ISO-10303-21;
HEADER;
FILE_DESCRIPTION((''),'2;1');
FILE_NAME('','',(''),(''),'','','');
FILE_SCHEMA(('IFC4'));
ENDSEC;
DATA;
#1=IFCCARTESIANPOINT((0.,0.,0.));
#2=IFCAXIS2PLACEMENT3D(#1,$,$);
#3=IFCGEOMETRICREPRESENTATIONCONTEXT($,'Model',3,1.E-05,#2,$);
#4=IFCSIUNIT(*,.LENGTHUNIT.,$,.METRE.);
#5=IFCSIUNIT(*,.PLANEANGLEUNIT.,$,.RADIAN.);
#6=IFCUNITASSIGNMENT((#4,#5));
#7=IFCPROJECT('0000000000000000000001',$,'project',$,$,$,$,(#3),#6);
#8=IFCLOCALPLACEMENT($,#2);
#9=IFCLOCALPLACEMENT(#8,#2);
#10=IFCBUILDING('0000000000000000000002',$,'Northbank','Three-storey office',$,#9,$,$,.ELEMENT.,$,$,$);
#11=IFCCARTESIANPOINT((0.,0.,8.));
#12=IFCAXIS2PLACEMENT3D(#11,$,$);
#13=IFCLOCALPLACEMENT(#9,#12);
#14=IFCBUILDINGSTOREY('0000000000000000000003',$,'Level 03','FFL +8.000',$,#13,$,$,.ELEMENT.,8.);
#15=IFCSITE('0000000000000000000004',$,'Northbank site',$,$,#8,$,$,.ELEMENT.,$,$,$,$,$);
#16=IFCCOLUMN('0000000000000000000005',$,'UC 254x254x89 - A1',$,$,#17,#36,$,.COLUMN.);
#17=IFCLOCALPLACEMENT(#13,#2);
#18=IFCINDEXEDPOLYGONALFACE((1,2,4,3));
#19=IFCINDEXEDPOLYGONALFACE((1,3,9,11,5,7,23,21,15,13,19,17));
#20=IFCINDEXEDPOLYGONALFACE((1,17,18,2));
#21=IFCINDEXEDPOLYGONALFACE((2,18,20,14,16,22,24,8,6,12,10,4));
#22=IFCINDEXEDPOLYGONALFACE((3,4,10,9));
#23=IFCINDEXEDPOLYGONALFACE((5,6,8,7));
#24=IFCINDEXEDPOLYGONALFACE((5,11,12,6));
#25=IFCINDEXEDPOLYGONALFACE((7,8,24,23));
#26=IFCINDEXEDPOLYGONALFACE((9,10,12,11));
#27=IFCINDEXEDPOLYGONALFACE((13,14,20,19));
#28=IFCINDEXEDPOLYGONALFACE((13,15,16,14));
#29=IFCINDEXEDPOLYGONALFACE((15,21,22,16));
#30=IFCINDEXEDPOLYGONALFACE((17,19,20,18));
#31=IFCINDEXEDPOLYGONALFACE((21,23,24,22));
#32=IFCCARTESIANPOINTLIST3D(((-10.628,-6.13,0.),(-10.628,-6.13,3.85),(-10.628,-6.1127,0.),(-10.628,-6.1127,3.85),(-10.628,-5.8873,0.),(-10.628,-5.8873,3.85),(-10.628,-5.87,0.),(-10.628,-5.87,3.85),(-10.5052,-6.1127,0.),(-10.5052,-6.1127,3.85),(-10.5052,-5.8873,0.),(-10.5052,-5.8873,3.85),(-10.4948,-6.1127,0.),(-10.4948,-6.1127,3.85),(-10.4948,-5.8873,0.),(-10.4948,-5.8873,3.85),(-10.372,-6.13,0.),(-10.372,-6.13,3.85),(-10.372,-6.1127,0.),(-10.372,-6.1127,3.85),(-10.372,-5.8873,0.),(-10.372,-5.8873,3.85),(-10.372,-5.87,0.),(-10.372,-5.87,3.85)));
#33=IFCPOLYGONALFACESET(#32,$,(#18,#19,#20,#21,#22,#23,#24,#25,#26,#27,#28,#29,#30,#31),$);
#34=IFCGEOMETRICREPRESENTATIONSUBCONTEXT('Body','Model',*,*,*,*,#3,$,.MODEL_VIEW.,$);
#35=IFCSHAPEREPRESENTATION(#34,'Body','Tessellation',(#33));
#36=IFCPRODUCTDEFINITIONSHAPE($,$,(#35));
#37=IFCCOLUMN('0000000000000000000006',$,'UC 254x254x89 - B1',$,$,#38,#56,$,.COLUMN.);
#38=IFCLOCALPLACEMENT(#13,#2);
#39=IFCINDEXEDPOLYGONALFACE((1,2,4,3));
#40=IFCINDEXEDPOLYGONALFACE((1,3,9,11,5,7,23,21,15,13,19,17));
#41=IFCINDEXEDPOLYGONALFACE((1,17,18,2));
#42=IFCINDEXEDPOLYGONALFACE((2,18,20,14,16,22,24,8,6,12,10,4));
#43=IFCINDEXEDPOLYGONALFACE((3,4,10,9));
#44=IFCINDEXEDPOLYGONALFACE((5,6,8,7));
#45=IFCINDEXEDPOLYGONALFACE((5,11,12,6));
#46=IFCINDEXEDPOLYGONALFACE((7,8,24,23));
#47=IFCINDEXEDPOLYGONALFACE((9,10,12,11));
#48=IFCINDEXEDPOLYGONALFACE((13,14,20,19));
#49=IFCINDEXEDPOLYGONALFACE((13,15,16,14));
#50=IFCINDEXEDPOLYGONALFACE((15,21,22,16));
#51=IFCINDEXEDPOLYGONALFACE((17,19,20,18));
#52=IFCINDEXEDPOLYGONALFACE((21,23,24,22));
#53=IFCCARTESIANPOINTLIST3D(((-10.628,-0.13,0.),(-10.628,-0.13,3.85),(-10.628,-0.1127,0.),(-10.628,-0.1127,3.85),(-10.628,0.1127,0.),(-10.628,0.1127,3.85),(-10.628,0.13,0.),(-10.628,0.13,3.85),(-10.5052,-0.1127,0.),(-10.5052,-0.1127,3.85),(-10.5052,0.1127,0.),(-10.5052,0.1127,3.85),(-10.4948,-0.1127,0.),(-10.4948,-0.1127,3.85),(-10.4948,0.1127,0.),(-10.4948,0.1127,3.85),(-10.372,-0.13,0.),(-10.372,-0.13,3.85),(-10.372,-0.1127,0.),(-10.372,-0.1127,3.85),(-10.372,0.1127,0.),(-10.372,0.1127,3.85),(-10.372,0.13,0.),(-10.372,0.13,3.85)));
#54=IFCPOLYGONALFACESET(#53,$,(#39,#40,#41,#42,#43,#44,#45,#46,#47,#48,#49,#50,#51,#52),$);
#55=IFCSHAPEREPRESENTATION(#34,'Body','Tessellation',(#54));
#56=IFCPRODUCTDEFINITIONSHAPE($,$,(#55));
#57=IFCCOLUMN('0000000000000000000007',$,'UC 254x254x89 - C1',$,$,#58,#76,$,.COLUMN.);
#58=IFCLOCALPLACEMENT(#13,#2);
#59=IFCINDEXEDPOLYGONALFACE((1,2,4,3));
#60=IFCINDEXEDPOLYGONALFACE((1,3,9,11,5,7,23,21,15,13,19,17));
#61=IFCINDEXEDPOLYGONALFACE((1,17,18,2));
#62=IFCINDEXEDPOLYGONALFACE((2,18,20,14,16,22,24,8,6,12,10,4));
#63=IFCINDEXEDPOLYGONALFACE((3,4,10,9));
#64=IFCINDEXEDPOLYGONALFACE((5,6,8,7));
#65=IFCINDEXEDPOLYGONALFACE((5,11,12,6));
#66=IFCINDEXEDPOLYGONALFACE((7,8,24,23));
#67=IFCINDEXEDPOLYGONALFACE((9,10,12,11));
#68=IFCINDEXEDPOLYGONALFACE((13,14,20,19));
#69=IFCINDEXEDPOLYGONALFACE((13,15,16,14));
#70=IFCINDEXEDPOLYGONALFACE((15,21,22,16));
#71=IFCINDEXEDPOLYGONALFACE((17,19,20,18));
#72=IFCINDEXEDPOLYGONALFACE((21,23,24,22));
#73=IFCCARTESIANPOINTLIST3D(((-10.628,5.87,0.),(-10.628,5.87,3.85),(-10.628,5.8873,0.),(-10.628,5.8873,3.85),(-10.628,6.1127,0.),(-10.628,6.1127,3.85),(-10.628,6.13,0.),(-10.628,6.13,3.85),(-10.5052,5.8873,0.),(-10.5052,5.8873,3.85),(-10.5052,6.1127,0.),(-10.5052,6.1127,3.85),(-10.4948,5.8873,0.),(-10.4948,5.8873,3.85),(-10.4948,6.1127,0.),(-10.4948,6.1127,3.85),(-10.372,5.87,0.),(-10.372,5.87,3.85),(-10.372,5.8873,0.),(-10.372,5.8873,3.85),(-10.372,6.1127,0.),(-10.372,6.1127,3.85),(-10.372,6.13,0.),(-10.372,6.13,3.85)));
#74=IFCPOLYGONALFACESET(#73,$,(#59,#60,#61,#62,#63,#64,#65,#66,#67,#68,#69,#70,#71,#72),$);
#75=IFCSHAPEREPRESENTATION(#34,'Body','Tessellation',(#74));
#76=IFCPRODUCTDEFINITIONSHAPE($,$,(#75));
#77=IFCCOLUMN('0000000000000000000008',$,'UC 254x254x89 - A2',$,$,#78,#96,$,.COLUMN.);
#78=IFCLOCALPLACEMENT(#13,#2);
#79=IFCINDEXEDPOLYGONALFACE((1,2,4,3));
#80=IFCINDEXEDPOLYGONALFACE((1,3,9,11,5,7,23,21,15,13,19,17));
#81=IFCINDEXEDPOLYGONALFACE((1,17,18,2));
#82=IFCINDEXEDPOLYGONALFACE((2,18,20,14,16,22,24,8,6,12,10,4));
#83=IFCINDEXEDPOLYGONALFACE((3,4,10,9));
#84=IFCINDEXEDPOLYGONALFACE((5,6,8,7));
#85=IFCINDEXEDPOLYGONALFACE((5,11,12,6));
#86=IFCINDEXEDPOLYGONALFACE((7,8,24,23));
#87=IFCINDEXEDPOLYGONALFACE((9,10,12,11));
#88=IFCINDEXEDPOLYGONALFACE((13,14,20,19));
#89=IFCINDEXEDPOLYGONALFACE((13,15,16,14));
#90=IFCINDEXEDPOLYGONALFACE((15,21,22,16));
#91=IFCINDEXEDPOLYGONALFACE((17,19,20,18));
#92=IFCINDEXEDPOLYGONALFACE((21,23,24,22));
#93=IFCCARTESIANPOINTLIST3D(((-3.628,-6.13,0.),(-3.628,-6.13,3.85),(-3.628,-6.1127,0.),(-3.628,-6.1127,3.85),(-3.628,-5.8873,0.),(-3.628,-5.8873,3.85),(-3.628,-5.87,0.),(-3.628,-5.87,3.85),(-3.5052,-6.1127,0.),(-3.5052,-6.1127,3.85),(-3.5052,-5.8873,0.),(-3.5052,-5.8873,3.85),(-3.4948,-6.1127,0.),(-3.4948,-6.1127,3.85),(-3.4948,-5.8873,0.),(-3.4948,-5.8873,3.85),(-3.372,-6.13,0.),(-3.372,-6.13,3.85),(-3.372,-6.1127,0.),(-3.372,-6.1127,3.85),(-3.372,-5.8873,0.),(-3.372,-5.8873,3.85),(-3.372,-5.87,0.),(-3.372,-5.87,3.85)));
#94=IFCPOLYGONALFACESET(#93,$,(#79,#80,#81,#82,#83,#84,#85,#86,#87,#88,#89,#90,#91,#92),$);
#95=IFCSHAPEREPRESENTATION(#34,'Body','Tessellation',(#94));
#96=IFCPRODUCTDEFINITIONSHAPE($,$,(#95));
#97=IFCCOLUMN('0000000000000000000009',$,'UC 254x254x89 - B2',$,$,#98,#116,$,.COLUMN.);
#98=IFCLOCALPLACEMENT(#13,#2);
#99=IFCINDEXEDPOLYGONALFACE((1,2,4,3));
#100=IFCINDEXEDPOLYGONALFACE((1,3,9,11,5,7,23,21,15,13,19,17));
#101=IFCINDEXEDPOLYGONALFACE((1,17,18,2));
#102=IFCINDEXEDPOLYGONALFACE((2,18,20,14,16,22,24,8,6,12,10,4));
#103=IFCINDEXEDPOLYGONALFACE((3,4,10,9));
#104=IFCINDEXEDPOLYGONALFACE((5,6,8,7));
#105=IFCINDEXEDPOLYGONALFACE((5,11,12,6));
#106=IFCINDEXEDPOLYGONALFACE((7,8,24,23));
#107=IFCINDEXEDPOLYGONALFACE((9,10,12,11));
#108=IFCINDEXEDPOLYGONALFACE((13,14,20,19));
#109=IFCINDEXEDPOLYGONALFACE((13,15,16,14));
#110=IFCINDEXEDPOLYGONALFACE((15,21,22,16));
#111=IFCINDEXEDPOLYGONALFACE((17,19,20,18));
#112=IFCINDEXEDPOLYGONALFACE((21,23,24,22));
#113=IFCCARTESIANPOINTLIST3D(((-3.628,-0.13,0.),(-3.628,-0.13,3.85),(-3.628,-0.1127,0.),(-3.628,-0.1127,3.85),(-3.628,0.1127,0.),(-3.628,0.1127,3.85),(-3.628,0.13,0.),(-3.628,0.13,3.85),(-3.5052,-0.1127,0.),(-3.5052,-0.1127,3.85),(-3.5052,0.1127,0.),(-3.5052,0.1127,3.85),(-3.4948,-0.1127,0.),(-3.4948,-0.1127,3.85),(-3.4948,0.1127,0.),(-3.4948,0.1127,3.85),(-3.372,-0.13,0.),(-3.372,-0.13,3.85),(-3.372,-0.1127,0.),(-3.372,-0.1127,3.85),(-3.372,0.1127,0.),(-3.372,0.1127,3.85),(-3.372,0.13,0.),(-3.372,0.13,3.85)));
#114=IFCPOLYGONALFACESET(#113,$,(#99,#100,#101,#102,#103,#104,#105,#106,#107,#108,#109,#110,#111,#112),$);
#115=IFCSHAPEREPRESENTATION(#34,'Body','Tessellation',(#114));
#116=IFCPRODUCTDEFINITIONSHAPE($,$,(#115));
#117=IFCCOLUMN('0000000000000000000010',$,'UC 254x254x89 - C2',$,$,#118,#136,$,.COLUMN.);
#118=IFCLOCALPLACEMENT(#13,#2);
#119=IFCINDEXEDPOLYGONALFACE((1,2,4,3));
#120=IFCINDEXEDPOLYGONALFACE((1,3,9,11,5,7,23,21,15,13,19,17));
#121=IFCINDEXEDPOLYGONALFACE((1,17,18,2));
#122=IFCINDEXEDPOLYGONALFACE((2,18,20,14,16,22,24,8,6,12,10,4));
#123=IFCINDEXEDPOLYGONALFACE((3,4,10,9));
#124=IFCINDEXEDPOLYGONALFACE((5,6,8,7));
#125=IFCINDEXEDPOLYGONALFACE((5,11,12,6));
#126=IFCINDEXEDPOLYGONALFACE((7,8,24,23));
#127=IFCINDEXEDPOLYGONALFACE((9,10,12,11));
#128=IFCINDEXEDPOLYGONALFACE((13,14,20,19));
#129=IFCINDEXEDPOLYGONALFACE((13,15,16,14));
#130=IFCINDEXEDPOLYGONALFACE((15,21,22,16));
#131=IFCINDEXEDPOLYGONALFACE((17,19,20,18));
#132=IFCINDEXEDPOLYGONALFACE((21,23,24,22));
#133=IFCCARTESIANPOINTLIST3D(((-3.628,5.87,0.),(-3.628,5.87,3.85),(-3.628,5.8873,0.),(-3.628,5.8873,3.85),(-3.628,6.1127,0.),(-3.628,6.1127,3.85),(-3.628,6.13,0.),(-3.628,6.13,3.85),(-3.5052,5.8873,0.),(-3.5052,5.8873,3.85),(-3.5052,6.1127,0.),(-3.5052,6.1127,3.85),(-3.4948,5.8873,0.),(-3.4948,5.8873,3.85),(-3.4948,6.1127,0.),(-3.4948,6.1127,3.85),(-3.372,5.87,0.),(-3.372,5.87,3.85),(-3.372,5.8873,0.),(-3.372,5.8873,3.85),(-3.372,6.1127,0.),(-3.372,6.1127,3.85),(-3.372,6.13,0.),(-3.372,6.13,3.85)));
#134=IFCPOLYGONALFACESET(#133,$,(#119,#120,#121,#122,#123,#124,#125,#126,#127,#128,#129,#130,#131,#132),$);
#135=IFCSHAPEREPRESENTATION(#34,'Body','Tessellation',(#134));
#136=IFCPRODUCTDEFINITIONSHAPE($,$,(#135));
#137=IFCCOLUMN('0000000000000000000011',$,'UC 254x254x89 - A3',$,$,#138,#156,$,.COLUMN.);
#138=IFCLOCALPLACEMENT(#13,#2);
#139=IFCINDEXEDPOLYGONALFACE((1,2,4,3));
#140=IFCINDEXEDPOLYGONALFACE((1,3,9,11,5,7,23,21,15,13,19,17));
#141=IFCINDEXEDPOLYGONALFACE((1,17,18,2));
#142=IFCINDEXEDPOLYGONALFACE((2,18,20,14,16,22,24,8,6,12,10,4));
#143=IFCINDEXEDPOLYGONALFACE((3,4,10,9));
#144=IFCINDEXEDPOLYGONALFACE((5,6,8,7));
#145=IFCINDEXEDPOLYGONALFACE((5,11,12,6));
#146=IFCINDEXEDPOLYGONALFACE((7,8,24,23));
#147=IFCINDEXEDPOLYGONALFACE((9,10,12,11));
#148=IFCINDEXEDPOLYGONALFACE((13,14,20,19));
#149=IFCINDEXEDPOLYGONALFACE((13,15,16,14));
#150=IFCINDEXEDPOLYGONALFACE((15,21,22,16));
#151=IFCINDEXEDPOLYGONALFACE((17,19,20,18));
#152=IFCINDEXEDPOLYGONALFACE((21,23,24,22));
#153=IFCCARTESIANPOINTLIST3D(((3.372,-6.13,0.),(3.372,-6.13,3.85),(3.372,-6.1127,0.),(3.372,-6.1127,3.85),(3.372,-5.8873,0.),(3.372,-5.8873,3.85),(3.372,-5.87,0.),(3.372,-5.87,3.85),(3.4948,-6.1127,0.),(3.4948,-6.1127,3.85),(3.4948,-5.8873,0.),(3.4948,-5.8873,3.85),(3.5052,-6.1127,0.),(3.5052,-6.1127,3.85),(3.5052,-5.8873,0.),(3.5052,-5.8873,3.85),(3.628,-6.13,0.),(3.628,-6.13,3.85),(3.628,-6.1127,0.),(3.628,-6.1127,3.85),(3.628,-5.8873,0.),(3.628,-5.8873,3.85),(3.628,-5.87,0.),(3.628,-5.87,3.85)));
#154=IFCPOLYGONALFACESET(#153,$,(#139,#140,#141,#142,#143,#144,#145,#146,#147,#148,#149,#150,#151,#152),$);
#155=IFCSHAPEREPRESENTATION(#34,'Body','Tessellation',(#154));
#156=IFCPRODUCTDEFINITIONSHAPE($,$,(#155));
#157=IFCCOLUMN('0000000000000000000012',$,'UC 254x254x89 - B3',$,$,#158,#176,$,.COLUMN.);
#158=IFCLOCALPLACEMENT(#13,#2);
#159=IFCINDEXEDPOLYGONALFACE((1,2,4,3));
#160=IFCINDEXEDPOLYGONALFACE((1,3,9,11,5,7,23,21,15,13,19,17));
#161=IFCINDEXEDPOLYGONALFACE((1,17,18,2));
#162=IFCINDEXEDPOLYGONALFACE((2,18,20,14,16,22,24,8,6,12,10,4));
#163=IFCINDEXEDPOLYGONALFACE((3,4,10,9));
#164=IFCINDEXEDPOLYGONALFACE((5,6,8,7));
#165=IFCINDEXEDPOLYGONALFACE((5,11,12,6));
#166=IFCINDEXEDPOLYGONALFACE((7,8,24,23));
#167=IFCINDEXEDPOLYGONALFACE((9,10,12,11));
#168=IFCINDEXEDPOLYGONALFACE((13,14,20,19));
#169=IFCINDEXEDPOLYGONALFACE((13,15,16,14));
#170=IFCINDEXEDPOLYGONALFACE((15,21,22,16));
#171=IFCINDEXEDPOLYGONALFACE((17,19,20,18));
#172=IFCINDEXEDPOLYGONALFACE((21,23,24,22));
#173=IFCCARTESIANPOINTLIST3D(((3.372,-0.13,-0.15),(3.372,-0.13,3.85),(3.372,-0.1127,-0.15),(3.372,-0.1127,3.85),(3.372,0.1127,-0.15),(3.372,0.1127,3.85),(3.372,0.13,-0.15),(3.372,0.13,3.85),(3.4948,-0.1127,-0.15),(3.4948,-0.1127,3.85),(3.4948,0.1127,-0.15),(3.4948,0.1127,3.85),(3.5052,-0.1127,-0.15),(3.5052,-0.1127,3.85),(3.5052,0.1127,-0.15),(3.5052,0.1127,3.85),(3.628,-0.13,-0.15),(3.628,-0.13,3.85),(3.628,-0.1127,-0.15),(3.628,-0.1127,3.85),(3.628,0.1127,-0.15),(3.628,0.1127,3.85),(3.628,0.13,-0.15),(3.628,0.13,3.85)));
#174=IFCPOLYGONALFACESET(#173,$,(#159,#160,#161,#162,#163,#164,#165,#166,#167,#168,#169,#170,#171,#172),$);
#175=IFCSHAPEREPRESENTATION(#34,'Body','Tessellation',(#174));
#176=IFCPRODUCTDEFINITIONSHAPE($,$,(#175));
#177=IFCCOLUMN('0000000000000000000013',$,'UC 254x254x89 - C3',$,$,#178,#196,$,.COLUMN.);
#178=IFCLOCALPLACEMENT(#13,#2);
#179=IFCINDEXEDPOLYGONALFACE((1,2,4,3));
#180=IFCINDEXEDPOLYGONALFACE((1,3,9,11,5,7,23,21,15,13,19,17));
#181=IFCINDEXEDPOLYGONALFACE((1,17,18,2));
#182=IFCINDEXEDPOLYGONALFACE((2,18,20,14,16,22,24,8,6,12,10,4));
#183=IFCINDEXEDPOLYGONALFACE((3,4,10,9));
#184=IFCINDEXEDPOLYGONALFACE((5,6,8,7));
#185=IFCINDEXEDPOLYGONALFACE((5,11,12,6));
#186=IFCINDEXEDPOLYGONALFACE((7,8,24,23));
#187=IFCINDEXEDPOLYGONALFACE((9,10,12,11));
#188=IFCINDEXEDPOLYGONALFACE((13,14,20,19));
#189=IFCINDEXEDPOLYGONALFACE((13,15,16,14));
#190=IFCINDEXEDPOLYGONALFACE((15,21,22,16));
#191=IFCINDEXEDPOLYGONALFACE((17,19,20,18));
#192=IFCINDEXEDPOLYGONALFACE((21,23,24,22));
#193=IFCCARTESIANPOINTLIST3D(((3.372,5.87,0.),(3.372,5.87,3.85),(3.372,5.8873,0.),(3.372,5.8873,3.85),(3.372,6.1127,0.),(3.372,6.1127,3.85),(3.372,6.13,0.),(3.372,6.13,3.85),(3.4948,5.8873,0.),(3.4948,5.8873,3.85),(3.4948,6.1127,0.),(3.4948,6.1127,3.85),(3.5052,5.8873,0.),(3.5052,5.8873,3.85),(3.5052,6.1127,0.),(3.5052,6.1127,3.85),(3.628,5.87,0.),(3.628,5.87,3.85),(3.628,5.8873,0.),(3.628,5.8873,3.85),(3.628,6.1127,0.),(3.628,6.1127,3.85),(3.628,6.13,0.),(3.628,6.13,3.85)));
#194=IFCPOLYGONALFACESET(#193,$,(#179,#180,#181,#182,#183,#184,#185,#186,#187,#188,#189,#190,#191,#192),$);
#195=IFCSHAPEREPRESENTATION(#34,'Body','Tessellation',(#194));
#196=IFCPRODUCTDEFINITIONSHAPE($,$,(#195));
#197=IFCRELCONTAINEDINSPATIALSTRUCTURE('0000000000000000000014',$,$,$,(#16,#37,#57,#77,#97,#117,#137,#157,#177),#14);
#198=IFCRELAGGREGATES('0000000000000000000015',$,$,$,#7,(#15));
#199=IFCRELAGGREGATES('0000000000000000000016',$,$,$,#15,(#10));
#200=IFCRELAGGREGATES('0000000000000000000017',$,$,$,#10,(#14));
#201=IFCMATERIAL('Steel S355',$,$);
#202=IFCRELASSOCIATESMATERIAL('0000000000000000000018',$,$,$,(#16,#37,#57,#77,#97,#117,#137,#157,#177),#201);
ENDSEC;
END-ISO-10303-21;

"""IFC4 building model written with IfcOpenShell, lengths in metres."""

from ifc_helpers import new_model, si_unit, frame, origin, place, context, subcontext, project, spatial, i_section, extrude, material, element, save


model = new_model("IFC4")

# Units and contexts
model_context = context("Model", 3, precision=1e-05, world=origin())
body_context = subcontext(model_context, "Body", "Model", "MODEL_VIEW")
ifc_project = project(units=[si_unit("LENGTHUNIT", "METRE"), si_unit("PLANEANGLEUNIT", "RADIAN")], contexts=[model_context])

# Site, building, storey
site_placement = place(None, origin())
site = spatial("IfcSite", under=ifc_project, at=site_placement, Name="Northbank site", CompositionType="ELEMENT")
building_placement = place(site_placement, origin())
building = spatial("IfcBuilding", under=site, at=building_placement, Name="Northbank", Description="Three-storey office", CompositionType="ELEMENT")
storey_placement = place(building_placement, frame((0.0, 0.0, 8.0)))
storey = spatial("IfcBuildingStorey", under=building, at=storey_placement, Name="Level 03", Description="FFL +8.000", CompositionType="ELEMENT", Elevation=8.0)

# Columns
ifc_material = material(Name="Steel S355")
column_1_placement = place(storey_placement, frame((0.0, 0.0, -8.0)))
element("IfcColumn", 1, at=column_1_placement, inside=storey, material=ifc_material, Name="UC 254x254x89 - A1", PredefinedType="COLUMN", context=body_context, shape_type="SweptSolid", body=[
    extrude(i_section(OverallWidth=0.256, OverallDepth=0.26, WebThickness=0.0103, FlangeThickness=0.0173), frame((-10.5, -6.0, 8.0), z_axis=(0.0, 0.0, 1.0), x_axis=(1.0, 0.0, 0.0)), (0.0, 0.0, 1.0), 3.85),
])
column_2_placement = place(storey_placement, frame((0.0, 0.0, -8.0)))
element("IfcColumn", 2, at=column_2_placement, inside=storey, material=ifc_material, Name="UC 254x254x89 - B1", PredefinedType="COLUMN", context=body_context, shape_type="SweptSolid", body=[
    extrude(i_section(OverallWidth=0.256, OverallDepth=0.26, WebThickness=0.0103, FlangeThickness=0.0173), frame((-10.5, 0.0, 8.0), z_axis=(0.0, 0.0, 1.0), x_axis=(1.0, 0.0, 0.0)), (0.0, 0.0, 1.0), 3.85),
])
column_3_placement = place(storey_placement, frame((0.0, 0.0, -8.0)))
element("IfcColumn", 3, at=column_3_placement, inside=storey, material=ifc_material, Name="UC 254x254x89 - C1", PredefinedType="COLUMN", context=body_context, shape_type="SweptSolid", body=[
    extrude(i_section(OverallWidth=0.256, OverallDepth=0.26, WebThickness=0.0103, FlangeThickness=0.0173), frame((-10.5, 6.0, 8.0), z_axis=(0.0, 0.0, 1.0), x_axis=(1.0, 0.0, 0.0)), (0.0, 0.0, 1.0), 3.85),
])
column_4_placement = place(storey_placement, frame((0.0, 0.0, -8.0)))
element("IfcColumn", 4, at=column_4_placement, inside=storey, material=ifc_material, Name="UC 254x254x89 - A2", PredefinedType="COLUMN", context=body_context, shape_type="SweptSolid", body=[
    extrude(i_section(OverallWidth=0.256, OverallDepth=0.26, WebThickness=0.0103, FlangeThickness=0.0173), frame((-3.5, -6.0, 8.0), z_axis=(0.0, 0.0, 1.0), x_axis=(1.0, 0.0, 0.0)), (0.0, 0.0, 1.0), 3.85),
])
column_5_placement = place(storey_placement, frame((0.0, 0.0, -8.0)))
element("IfcColumn", 5, at=column_5_placement, inside=storey, material=ifc_material, Name="UC 254x254x89 - B2", PredefinedType="COLUMN", context=body_context, shape_type="SweptSolid", body=[
    extrude(i_section(OverallWidth=0.256, OverallDepth=0.26, WebThickness=0.0103, FlangeThickness=0.0173), frame((-3.5, 0.0, 8.0), z_axis=(0.0, 0.0, 1.0), x_axis=(1.0, 0.0, 0.0)), (0.0, 0.0, 1.0), 3.85),
])
column_6_placement = place(storey_placement, frame((0.0, 0.0, -8.0)))
element("IfcColumn", 6, at=column_6_placement, inside=storey, material=ifc_material, Name="UC 254x254x89 - C2", PredefinedType="COLUMN", context=body_context, shape_type="SweptSolid", body=[
    extrude(i_section(OverallWidth=0.256, OverallDepth=0.26, WebThickness=0.0103, FlangeThickness=0.0173), frame((-3.5, 6.0, 8.0), z_axis=(0.0, 0.0, 1.0), x_axis=(1.0, 0.0, 0.0)), (0.0, 0.0, 1.0), 3.85),
])
column_7_placement = place(storey_placement, frame((0.0, 0.0, -8.0)))
element("IfcColumn", 7, at=column_7_placement, inside=storey, material=ifc_material, Name="UC 254x254x89 - A3", PredefinedType="COLUMN", context=body_context, shape_type="SweptSolid", body=[
    extrude(i_section(OverallWidth=0.256, OverallDepth=0.26, WebThickness=0.0103, FlangeThickness=0.0173), frame((3.5, -6.0, 8.0), z_axis=(0.0, 0.0, 1.0), x_axis=(1.0, 0.0, 0.0)), (0.0, 0.0, 1.0), 3.85),
])
column_8_placement = place(storey_placement, frame((0.0, 0.0, -8.0)))
element("IfcColumn", 8, at=column_8_placement, inside=storey, material=ifc_material, Name="UC 254x254x89 - B3", PredefinedType="COLUMN", context=body_context, shape_type="SweptSolid", body=[
    extrude(i_section(OverallWidth=0.256, OverallDepth=0.26, WebThickness=0.0103, FlangeThickness=0.0173), frame((3.5, 0.0, 7.85), z_axis=(0.0, 0.0, 1.0), x_axis=(1.0, 0.0, 0.0)), (0.0, 0.0, 1.0), 4.0),
])
column_9_placement = place(storey_placement, frame((0.0, 0.0, -8.0)))
element("IfcColumn", 9, at=column_9_placement, inside=storey, material=ifc_material, Name="UC 254x254x89 - C3", PredefinedType="COLUMN", context=body_context, shape_type="SweptSolid", body=[
    extrude(i_section(OverallWidth=0.256, OverallDepth=0.26, WebThickness=0.0103, FlangeThickness=0.0173), frame((3.5, 6.0, 8.0), z_axis=(0.0, 0.0, 1.0), x_axis=(1.0, 0.0, 0.0)), (0.0, 0.0, 1.0), 3.85),
])

save(model, "model.ifc")
